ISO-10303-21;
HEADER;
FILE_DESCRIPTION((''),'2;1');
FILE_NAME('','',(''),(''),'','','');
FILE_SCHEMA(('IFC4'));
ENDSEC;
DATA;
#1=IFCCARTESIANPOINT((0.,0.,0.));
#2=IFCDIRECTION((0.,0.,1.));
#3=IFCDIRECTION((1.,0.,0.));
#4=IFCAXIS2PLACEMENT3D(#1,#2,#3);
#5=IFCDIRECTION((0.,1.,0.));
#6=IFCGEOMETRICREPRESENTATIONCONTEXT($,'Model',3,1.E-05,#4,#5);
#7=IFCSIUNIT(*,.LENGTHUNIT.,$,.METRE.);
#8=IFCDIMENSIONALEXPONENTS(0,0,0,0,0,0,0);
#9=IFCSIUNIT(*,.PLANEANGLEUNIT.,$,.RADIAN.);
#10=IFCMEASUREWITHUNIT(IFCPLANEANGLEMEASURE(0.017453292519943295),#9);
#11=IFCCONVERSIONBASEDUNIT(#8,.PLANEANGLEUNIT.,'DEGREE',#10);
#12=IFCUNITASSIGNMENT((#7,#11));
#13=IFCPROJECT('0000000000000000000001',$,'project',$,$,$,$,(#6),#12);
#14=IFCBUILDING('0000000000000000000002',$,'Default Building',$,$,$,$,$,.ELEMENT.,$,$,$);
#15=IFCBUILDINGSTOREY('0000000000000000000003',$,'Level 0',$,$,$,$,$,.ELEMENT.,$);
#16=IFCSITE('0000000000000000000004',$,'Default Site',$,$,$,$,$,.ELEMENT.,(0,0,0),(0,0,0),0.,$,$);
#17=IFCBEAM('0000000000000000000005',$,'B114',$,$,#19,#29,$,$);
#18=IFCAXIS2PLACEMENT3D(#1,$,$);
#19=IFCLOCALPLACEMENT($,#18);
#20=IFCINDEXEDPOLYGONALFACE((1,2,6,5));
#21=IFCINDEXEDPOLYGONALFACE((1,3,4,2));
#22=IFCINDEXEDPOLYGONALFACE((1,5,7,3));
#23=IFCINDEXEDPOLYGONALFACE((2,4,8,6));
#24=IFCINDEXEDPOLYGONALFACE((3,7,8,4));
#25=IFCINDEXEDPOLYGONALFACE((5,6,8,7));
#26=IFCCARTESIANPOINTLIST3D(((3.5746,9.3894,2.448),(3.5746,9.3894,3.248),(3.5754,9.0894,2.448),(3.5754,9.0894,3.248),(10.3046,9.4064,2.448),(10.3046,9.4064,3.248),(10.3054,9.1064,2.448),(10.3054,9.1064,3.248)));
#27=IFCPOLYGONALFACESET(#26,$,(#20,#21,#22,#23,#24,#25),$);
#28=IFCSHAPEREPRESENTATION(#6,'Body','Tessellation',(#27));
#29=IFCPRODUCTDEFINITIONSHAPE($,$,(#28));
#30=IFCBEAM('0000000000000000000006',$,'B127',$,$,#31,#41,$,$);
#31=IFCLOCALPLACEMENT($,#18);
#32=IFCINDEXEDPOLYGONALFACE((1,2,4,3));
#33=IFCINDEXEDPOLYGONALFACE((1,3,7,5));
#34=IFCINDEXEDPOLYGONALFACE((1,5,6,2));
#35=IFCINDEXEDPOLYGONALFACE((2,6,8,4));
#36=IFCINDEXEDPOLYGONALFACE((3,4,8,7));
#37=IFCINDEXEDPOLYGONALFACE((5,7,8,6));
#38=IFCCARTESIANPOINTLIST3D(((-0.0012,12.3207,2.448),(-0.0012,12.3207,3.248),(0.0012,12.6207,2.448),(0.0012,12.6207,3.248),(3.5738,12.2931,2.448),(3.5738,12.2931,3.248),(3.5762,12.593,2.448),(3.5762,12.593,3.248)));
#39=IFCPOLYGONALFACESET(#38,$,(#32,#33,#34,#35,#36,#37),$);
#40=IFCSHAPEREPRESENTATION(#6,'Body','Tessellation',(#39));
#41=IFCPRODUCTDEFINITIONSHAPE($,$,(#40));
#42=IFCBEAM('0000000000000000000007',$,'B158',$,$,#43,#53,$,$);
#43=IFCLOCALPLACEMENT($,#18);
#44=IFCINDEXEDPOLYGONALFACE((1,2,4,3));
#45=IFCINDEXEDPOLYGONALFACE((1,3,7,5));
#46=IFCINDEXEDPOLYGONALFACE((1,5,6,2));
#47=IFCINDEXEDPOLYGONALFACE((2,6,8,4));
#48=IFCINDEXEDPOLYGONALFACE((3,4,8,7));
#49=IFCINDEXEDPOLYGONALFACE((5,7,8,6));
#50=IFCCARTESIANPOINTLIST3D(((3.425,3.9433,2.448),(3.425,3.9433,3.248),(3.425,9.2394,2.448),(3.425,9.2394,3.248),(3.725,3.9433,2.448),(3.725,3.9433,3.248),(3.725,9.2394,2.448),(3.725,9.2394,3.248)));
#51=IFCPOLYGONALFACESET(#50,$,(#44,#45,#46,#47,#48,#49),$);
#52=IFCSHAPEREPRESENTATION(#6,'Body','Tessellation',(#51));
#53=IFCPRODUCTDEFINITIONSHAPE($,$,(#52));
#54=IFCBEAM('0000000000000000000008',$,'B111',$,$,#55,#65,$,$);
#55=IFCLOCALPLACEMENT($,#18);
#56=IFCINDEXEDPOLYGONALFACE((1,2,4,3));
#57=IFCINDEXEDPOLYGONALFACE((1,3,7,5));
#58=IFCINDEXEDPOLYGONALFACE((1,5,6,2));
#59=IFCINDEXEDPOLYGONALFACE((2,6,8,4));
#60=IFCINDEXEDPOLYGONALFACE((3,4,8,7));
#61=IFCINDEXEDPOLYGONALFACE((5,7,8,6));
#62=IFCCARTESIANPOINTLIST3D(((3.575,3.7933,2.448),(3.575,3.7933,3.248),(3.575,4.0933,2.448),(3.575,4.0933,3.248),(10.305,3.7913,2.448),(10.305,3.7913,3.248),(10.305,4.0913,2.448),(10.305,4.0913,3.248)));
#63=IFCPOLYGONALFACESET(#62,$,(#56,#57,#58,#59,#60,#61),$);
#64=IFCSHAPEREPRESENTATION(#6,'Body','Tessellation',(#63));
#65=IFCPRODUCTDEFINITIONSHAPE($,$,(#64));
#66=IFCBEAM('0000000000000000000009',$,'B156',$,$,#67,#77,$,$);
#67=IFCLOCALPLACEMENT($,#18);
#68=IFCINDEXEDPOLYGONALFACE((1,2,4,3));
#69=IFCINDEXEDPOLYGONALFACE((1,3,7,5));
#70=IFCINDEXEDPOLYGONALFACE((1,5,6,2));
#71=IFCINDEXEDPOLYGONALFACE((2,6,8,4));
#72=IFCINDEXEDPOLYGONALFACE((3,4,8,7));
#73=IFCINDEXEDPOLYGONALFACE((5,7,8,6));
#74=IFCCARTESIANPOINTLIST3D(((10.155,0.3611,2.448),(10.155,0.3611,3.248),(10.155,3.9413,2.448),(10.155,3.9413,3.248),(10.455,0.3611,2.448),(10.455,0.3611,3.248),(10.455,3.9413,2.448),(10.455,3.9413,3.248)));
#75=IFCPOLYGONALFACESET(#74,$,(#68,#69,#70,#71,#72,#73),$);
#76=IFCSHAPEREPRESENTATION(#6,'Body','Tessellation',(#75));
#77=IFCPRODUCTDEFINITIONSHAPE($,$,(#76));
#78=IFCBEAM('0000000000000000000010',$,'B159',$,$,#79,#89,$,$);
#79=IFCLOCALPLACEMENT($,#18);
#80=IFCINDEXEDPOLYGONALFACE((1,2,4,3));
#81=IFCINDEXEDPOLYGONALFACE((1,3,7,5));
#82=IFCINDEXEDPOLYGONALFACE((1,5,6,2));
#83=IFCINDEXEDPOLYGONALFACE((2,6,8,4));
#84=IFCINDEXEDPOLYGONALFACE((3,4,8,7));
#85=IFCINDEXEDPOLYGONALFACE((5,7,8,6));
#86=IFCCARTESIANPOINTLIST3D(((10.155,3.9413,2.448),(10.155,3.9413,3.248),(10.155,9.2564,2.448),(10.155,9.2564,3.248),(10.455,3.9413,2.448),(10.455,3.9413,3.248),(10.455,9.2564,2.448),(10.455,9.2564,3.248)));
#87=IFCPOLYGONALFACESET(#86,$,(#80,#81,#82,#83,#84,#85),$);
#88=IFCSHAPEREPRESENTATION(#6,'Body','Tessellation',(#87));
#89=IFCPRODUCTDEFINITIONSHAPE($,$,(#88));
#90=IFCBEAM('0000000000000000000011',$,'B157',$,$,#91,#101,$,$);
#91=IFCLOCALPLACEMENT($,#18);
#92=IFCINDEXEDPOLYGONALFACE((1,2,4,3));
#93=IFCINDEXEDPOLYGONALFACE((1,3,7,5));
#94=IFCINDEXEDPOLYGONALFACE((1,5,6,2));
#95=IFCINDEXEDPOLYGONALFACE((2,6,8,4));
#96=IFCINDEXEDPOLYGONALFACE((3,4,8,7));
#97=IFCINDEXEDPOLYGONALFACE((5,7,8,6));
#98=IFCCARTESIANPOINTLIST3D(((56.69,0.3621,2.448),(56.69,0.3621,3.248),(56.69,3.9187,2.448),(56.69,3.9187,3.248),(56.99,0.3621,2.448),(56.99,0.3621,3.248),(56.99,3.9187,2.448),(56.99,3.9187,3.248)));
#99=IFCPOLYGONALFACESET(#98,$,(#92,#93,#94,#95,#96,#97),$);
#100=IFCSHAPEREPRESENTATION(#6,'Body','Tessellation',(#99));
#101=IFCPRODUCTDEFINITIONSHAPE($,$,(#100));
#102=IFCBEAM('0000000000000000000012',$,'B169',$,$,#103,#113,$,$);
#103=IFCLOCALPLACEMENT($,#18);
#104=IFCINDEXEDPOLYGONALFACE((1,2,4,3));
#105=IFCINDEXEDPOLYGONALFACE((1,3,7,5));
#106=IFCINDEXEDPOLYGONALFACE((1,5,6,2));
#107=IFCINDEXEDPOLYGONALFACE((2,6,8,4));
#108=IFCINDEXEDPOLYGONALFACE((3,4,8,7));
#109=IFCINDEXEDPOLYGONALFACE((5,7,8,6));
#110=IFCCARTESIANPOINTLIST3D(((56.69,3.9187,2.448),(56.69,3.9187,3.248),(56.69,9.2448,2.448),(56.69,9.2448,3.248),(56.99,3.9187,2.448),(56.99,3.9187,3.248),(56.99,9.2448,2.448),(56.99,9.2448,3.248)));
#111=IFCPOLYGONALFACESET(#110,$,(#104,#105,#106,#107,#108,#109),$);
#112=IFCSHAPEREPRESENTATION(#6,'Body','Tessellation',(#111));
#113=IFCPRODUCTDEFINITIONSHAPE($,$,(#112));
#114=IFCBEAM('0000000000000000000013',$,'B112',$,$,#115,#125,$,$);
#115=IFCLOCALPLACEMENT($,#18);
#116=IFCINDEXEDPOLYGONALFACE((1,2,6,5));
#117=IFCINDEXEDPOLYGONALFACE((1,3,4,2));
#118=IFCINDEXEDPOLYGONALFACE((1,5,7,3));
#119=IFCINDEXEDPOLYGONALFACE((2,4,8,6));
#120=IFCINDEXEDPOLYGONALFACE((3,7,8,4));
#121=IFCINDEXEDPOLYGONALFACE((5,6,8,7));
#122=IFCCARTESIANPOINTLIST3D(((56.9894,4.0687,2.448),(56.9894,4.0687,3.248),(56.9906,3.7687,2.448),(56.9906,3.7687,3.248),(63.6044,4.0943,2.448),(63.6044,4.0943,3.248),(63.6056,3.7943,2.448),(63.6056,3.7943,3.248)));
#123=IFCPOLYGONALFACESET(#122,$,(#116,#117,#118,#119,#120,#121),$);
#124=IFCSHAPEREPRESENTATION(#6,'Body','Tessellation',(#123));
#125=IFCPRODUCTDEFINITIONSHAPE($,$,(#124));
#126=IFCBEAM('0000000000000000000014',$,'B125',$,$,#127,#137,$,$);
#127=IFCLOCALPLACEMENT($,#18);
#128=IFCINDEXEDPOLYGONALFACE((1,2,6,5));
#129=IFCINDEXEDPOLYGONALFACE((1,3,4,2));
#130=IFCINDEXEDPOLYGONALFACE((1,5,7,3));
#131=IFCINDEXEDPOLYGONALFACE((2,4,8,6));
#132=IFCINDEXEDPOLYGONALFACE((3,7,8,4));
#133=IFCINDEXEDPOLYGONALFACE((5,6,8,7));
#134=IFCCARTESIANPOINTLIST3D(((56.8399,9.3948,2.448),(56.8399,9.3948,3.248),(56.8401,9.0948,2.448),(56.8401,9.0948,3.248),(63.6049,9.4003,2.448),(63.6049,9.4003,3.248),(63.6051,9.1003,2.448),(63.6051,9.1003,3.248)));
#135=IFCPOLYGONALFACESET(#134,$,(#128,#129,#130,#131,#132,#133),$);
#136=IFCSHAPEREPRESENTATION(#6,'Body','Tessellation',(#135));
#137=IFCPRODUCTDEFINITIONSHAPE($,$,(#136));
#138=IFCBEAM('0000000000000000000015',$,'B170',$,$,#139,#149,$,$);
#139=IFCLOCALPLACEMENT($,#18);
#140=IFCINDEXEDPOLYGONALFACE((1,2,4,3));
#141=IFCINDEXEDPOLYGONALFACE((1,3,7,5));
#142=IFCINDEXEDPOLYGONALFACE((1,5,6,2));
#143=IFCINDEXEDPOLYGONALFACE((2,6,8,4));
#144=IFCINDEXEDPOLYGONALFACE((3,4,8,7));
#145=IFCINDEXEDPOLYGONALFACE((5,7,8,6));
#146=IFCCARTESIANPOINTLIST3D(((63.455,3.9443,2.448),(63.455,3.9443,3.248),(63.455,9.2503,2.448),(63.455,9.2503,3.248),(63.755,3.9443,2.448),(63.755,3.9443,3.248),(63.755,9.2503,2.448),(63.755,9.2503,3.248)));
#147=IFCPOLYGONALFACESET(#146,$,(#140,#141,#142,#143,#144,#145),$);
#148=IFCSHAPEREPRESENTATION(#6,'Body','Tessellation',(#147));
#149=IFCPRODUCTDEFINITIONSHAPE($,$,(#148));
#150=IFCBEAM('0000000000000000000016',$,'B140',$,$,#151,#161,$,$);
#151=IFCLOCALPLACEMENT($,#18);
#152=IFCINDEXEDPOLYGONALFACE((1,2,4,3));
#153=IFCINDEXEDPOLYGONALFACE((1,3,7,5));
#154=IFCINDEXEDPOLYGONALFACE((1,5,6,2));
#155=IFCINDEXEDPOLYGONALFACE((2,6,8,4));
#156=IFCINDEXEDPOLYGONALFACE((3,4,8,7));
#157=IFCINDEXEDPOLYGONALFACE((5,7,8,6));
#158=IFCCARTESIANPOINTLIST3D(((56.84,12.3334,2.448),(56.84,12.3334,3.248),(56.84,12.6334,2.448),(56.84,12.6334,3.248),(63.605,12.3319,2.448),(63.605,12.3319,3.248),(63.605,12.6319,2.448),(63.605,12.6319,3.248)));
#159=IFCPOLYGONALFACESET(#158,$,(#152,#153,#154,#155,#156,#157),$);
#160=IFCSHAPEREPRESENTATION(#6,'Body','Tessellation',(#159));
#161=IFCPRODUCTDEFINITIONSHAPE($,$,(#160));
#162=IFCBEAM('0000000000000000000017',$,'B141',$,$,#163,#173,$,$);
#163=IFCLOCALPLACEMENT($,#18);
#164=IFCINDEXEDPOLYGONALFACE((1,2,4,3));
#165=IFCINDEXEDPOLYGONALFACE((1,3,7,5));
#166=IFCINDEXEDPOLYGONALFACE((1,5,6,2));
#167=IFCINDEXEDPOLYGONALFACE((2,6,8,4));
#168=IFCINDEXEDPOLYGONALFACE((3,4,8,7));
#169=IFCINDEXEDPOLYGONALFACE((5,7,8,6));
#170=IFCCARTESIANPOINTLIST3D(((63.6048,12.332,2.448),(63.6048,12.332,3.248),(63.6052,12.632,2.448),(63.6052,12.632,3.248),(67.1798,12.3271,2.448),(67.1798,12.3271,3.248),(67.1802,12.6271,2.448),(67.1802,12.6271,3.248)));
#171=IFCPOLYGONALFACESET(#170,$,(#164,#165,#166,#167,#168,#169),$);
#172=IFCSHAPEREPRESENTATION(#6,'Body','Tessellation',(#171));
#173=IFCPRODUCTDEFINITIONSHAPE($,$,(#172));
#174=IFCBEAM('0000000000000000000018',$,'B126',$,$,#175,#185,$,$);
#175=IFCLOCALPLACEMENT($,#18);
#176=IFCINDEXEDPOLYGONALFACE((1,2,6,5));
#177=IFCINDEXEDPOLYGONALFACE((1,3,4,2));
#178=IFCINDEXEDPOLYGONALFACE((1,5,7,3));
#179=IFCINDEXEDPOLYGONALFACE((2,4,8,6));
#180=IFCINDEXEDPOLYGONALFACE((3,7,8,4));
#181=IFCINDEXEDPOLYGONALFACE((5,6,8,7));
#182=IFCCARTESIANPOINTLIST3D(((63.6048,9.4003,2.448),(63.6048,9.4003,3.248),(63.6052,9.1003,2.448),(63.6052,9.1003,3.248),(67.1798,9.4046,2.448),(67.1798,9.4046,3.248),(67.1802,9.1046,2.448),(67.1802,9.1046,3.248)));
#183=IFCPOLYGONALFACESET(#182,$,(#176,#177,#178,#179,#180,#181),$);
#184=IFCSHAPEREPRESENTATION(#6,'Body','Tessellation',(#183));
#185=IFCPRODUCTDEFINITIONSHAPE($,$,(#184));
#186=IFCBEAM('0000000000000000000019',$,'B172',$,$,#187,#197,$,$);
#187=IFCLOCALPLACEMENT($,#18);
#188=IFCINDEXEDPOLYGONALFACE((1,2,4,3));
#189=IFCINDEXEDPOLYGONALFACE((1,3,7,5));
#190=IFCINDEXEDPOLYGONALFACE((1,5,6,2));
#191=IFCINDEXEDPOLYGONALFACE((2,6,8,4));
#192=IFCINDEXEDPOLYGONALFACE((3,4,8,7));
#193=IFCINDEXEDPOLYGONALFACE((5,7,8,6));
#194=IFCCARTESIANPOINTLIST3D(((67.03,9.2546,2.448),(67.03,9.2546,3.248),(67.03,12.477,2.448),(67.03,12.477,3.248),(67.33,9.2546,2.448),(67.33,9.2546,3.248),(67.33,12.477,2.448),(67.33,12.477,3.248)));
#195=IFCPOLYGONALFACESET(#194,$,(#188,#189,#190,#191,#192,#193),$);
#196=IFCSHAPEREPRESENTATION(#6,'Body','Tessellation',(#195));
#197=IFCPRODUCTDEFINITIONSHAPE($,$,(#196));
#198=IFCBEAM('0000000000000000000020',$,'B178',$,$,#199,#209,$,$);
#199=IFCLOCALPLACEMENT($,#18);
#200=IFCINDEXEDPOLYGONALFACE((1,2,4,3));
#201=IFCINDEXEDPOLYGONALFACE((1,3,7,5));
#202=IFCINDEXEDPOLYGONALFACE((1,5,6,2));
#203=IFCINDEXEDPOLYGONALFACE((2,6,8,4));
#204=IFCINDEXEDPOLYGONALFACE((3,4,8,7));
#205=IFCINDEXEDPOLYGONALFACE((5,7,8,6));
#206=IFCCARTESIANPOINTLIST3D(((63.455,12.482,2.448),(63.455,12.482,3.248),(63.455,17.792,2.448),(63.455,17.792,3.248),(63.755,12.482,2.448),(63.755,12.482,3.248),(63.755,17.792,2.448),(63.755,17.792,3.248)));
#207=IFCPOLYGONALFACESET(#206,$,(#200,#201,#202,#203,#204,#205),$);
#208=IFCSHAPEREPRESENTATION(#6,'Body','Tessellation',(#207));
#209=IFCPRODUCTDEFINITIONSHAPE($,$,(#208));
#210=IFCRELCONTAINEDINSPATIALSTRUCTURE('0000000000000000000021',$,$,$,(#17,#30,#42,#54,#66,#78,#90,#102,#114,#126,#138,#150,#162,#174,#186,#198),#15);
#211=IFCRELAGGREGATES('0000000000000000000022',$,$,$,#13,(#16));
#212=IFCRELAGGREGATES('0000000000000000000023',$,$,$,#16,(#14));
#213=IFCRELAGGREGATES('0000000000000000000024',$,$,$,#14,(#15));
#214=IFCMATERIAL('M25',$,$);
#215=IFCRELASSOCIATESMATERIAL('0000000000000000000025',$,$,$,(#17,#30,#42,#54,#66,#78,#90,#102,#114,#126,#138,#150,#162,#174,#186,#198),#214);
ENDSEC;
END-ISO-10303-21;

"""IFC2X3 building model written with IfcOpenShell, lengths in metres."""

from ifc_helpers import new_model, entity, si_unit, converted_unit, direction, frame, frame_2d, origin_with_axes, place, context, project, spatial, rectangle, extrude, material, element, save


model = new_model("IFC2X3")

# Units and contexts
model_context = context("Model", 3, precision=1e-05, world=origin_with_axes(), true_north=direction((0.0, 1.0, 0.0)))
ifc_project = project(units=[si_unit("LENGTHUNIT", "METRE"), converted_unit("PLANEANGLEUNIT", "DEGREE", entity("IfcPlaneAngleMeasure", 0.017453292519943295), si_unit("PLANEANGLEUNIT", "RADIAN"), dimensions=[0, 0, 0, 0, 0, 0, 0])], contexts=[model_context])

# Site, building, storey
site = spatial("IfcSite", under=ifc_project, Name="Default Site", CompositionType="ELEMENT", RefLatitude=(0, 0, 0), RefLongitude=(0, 0, 0), RefElevation=0.0)
building = spatial("IfcBuilding", under=site, Name="Default Building", CompositionType="ELEMENT")
storey = spatial("IfcBuildingStorey", under=building, Name="Level 0", CompositionType="ELEMENT")

# Beams
ifc_material = material(Name="M25")
placement = place(None, origin_with_axes())
element("IfcBeam", 1, at=placement, inside=storey, material=ifc_material, Name="B114", context=model_context, shape_type="SweptSolid", body=[
    extrude(rectangle(XDim=0.3, YDim=0.8, at=frame_2d((0.0, 0.0), x_axis=(0.0, 1.0, 0.0))), frame((3.575, 9.2394, 2.848), z_axis=(0.999997, 0.002522, 0.0), x_axis=(0.0, 0.0, -1.0)), (0.0, 0.0, 1.0), 6.73),
])
element("IfcBeam", 2, at=placement, inside=storey, material=ifc_material, Name="B127", context=model_context, shape_type="SweptSolid", body=[
    extrude(rectangle(XDim=0.3, YDim=0.8, at=frame_2d((0.0, 0.0), x_axis=(0.0, 1.0, 0.0))), frame((0.0, 12.4707, 2.848), z_axis=(0.99997, -0.007734, 0.0), x_axis=(0.0, 0.0, -1.0)), (0.0, 0.0, 1.0), 3.5751),
])
element("IfcBeam", 3, at=placement, inside=storey, material=ifc_material, Name="B158", context=model_context, shape_type="SweptSolid", body=[
    extrude(rectangle(XDim=0.3, YDim=0.8, at=frame_2d((0.0, 0.0), x_axis=(0.0, 1.0, 0.0))), frame((3.575, 3.9433, 2.848), z_axis=(0.0, 1.0, 0.0), x_axis=(0.0, 0.0, -1.0)), (0.0, 0.0, 1.0), 5.2961),
])
element("IfcBeam", 4, at=placement, inside=storey, material=ifc_material, Name="B111", context=model_context, shape_type="SweptSolid", body=[
    extrude(rectangle(XDim=0.3, YDim=0.8, at=frame_2d((0.0, 0.0), x_axis=(0.0, 1.0, 0.0))), frame((3.575, 3.9433, 2.848), z_axis=(1.0, -0.000302, 0.0), x_axis=(0.0, 0.0, -1.0)), (0.0, 0.0, 1.0), 6.73),
])
element("IfcBeam", 5, at=placement, inside=storey, material=ifc_material, Name="B156", context=model_context, shape_type="SweptSolid", body=[
    extrude(rectangle(XDim=0.3, YDim=0.8, at=frame_2d((0.0, 0.0), x_axis=(0.0, 1.0, 0.0))), frame((10.305, 3.9413, 2.848), z_axis=(0.0, -1.0, 0.0), x_axis=(0.0, 0.0, -1.0)), (0.0, 0.0, 1.0), 3.5802),
])
element("IfcBeam", 6, at=placement, inside=storey, material=ifc_material, Name="B159", context=model_context, shape_type="SweptSolid", body=[
    extrude(rectangle(XDim=0.3, YDim=0.8, at=frame_2d((0.0, 0.0), x_axis=(0.0, 1.0, 0.0))), frame((10.305, 3.9413, 2.848), z_axis=(0.0, 1.0, 0.0), x_axis=(0.0, 0.0, -1.0)), (0.0, 0.0, 1.0), 5.3151),
])
element("IfcBeam", 7, at=placement, inside=storey, material=ifc_material, Name="B157", context=model_context, shape_type="SweptSolid", body=[
    extrude(rectangle(XDim=0.3, YDim=0.8, at=frame_2d((0.0, 0.0), x_axis=(0.0, 1.0, 0.0))), frame((56.84, 0.3621, 2.848), z_axis=(0.0, 1.0, 0.0), x_axis=(0.0, 0.0, -1.0)), (0.0, 0.0, 1.0), 3.5566),
])
element("IfcBeam", 8, at=placement, inside=storey, material=ifc_material, Name="B169", context=model_context, shape_type="SweptSolid", body=[
    extrude(rectangle(XDim=0.3, YDim=0.8, at=frame_2d((0.0, 0.0), x_axis=(0.0, 1.0, 0.0))), frame((56.84, 3.9187, 2.848), z_axis=(0.0, 1.0, 0.0), x_axis=(0.0, 0.0, -1.0)), (0.0, 0.0, 1.0), 5.3261),
])
element("IfcBeam", 9, at=placement, inside=storey, material=ifc_material, Name="B112", context=model_context, shape_type="SweptSolid", body=[
    extrude(rectangle(XDim=0.3, YDim=0.8, at=frame_2d((0.0, 0.0), x_axis=(0.0, 1.0, 0.0))), frame((56.99, 3.9187, 2.848), z_axis=(0.999993, 0.003873, 0.0), x_axis=(0.0, 0.0, -1.0)), (0.0, 0.0, 1.0), 6.6151),
])
element("IfcBeam", 10, at=placement, inside=storey, material=ifc_material, Name="B125", context=model_context, shape_type="SweptSolid", body=[
    extrude(rectangle(XDim=0.3, YDim=0.8, at=frame_2d((0.0, 0.0), x_axis=(0.0, 1.0, 0.0))), frame((56.84, 9.2448, 2.848), z_axis=(1.0, 0.000816, 0.0), x_axis=(0.0, 0.0, -1.0)), (0.0, 0.0, 1.0), 6.765),
])
element("IfcBeam", 11, at=placement, inside=storey, material=ifc_material, Name="B170", context=model_context, shape_type="SweptSolid", body=[
    extrude(rectangle(XDim=0.3, YDim=0.8, at=frame_2d((0.0, 0.0), x_axis=(0.0, 1.0, 0.0))), frame((63.605, 3.9443, 2.848), z_axis=(0.0, 1.0, 0.0), x_axis=(0.0, 0.0, -1.0)), (0.0, 0.0, 1.0), 5.306),
])
element("IfcBeam", 12, at=placement, inside=storey, material=ifc_material, Name="B140", context=model_context, shape_type="SweptSolid", body=[
    extrude(rectangle(XDim=0.3, YDim=0.8, at=frame_2d((0.0, 0.0), x_axis=(0.0, 1.0, 0.0))), frame((56.84, 12.4834, 2.848), z_axis=(1.0, -0.000216, 0.0), x_axis=(0.0, 0.0, -1.0)), (0.0, 0.0, 1.0), 6.765),
])
element("IfcBeam", 13, at=placement, inside=storey, material=ifc_material, Name="B141", context=model_context, shape_type="SweptSolid", body=[
    extrude(rectangle(XDim=0.3, YDim=0.8, at=frame_2d((0.0, 0.0), x_axis=(0.0, 1.0, 0.0))), frame((63.605, 12.482, 2.848), z_axis=(0.999999, -0.001379, 0.0), x_axis=(0.0, 0.0, -1.0)), (0.0, 0.0, 1.0), 3.575),
])
element("IfcBeam", 14, at=placement, inside=storey, material=ifc_material, Name="B126", context=model_context, shape_type="SweptSolid", body=[
    extrude(rectangle(XDim=0.3, YDim=0.8, at=frame_2d((0.0, 0.0), x_axis=(0.0, 1.0, 0.0))), frame((63.605, 9.2503, 2.848), z_axis=(0.999999, 0.001188, 0.0), x_axis=(0.0, 0.0, -1.0)), (0.0, 0.0, 1.0), 3.575),
])
element("IfcBeam", 15, at=placement, inside=storey, material=ifc_material, Name="B172", context=model_context, shape_type="SweptSolid", body=[
    extrude(rectangle(XDim=0.3, YDim=0.8, at=frame_2d((0.0, 0.0), x_axis=(0.0, 1.0, 0.0))), frame((67.18, 9.2546, 2.848), z_axis=(0.0, 1.0, 0.0), x_axis=(0.0, 0.0, -1.0)), (0.0, 0.0, 1.0), 3.2224),
])
element("IfcBeam", 16, at=placement, inside=storey, material=ifc_material, Name="B178", context=model_context, shape_type="SweptSolid", body=[
    extrude(rectangle(XDim=0.3, YDim=0.8, at=frame_2d((0.0, 0.0), x_axis=(0.0, 1.0, 0.0))), frame((63.605, 12.482, 2.848), z_axis=(0.0, 1.0, 0.0), x_axis=(0.0, 0.0, -1.0)), (0.0, 0.0, 1.0), 5.3101),
])

save(model, "model.ifc")
